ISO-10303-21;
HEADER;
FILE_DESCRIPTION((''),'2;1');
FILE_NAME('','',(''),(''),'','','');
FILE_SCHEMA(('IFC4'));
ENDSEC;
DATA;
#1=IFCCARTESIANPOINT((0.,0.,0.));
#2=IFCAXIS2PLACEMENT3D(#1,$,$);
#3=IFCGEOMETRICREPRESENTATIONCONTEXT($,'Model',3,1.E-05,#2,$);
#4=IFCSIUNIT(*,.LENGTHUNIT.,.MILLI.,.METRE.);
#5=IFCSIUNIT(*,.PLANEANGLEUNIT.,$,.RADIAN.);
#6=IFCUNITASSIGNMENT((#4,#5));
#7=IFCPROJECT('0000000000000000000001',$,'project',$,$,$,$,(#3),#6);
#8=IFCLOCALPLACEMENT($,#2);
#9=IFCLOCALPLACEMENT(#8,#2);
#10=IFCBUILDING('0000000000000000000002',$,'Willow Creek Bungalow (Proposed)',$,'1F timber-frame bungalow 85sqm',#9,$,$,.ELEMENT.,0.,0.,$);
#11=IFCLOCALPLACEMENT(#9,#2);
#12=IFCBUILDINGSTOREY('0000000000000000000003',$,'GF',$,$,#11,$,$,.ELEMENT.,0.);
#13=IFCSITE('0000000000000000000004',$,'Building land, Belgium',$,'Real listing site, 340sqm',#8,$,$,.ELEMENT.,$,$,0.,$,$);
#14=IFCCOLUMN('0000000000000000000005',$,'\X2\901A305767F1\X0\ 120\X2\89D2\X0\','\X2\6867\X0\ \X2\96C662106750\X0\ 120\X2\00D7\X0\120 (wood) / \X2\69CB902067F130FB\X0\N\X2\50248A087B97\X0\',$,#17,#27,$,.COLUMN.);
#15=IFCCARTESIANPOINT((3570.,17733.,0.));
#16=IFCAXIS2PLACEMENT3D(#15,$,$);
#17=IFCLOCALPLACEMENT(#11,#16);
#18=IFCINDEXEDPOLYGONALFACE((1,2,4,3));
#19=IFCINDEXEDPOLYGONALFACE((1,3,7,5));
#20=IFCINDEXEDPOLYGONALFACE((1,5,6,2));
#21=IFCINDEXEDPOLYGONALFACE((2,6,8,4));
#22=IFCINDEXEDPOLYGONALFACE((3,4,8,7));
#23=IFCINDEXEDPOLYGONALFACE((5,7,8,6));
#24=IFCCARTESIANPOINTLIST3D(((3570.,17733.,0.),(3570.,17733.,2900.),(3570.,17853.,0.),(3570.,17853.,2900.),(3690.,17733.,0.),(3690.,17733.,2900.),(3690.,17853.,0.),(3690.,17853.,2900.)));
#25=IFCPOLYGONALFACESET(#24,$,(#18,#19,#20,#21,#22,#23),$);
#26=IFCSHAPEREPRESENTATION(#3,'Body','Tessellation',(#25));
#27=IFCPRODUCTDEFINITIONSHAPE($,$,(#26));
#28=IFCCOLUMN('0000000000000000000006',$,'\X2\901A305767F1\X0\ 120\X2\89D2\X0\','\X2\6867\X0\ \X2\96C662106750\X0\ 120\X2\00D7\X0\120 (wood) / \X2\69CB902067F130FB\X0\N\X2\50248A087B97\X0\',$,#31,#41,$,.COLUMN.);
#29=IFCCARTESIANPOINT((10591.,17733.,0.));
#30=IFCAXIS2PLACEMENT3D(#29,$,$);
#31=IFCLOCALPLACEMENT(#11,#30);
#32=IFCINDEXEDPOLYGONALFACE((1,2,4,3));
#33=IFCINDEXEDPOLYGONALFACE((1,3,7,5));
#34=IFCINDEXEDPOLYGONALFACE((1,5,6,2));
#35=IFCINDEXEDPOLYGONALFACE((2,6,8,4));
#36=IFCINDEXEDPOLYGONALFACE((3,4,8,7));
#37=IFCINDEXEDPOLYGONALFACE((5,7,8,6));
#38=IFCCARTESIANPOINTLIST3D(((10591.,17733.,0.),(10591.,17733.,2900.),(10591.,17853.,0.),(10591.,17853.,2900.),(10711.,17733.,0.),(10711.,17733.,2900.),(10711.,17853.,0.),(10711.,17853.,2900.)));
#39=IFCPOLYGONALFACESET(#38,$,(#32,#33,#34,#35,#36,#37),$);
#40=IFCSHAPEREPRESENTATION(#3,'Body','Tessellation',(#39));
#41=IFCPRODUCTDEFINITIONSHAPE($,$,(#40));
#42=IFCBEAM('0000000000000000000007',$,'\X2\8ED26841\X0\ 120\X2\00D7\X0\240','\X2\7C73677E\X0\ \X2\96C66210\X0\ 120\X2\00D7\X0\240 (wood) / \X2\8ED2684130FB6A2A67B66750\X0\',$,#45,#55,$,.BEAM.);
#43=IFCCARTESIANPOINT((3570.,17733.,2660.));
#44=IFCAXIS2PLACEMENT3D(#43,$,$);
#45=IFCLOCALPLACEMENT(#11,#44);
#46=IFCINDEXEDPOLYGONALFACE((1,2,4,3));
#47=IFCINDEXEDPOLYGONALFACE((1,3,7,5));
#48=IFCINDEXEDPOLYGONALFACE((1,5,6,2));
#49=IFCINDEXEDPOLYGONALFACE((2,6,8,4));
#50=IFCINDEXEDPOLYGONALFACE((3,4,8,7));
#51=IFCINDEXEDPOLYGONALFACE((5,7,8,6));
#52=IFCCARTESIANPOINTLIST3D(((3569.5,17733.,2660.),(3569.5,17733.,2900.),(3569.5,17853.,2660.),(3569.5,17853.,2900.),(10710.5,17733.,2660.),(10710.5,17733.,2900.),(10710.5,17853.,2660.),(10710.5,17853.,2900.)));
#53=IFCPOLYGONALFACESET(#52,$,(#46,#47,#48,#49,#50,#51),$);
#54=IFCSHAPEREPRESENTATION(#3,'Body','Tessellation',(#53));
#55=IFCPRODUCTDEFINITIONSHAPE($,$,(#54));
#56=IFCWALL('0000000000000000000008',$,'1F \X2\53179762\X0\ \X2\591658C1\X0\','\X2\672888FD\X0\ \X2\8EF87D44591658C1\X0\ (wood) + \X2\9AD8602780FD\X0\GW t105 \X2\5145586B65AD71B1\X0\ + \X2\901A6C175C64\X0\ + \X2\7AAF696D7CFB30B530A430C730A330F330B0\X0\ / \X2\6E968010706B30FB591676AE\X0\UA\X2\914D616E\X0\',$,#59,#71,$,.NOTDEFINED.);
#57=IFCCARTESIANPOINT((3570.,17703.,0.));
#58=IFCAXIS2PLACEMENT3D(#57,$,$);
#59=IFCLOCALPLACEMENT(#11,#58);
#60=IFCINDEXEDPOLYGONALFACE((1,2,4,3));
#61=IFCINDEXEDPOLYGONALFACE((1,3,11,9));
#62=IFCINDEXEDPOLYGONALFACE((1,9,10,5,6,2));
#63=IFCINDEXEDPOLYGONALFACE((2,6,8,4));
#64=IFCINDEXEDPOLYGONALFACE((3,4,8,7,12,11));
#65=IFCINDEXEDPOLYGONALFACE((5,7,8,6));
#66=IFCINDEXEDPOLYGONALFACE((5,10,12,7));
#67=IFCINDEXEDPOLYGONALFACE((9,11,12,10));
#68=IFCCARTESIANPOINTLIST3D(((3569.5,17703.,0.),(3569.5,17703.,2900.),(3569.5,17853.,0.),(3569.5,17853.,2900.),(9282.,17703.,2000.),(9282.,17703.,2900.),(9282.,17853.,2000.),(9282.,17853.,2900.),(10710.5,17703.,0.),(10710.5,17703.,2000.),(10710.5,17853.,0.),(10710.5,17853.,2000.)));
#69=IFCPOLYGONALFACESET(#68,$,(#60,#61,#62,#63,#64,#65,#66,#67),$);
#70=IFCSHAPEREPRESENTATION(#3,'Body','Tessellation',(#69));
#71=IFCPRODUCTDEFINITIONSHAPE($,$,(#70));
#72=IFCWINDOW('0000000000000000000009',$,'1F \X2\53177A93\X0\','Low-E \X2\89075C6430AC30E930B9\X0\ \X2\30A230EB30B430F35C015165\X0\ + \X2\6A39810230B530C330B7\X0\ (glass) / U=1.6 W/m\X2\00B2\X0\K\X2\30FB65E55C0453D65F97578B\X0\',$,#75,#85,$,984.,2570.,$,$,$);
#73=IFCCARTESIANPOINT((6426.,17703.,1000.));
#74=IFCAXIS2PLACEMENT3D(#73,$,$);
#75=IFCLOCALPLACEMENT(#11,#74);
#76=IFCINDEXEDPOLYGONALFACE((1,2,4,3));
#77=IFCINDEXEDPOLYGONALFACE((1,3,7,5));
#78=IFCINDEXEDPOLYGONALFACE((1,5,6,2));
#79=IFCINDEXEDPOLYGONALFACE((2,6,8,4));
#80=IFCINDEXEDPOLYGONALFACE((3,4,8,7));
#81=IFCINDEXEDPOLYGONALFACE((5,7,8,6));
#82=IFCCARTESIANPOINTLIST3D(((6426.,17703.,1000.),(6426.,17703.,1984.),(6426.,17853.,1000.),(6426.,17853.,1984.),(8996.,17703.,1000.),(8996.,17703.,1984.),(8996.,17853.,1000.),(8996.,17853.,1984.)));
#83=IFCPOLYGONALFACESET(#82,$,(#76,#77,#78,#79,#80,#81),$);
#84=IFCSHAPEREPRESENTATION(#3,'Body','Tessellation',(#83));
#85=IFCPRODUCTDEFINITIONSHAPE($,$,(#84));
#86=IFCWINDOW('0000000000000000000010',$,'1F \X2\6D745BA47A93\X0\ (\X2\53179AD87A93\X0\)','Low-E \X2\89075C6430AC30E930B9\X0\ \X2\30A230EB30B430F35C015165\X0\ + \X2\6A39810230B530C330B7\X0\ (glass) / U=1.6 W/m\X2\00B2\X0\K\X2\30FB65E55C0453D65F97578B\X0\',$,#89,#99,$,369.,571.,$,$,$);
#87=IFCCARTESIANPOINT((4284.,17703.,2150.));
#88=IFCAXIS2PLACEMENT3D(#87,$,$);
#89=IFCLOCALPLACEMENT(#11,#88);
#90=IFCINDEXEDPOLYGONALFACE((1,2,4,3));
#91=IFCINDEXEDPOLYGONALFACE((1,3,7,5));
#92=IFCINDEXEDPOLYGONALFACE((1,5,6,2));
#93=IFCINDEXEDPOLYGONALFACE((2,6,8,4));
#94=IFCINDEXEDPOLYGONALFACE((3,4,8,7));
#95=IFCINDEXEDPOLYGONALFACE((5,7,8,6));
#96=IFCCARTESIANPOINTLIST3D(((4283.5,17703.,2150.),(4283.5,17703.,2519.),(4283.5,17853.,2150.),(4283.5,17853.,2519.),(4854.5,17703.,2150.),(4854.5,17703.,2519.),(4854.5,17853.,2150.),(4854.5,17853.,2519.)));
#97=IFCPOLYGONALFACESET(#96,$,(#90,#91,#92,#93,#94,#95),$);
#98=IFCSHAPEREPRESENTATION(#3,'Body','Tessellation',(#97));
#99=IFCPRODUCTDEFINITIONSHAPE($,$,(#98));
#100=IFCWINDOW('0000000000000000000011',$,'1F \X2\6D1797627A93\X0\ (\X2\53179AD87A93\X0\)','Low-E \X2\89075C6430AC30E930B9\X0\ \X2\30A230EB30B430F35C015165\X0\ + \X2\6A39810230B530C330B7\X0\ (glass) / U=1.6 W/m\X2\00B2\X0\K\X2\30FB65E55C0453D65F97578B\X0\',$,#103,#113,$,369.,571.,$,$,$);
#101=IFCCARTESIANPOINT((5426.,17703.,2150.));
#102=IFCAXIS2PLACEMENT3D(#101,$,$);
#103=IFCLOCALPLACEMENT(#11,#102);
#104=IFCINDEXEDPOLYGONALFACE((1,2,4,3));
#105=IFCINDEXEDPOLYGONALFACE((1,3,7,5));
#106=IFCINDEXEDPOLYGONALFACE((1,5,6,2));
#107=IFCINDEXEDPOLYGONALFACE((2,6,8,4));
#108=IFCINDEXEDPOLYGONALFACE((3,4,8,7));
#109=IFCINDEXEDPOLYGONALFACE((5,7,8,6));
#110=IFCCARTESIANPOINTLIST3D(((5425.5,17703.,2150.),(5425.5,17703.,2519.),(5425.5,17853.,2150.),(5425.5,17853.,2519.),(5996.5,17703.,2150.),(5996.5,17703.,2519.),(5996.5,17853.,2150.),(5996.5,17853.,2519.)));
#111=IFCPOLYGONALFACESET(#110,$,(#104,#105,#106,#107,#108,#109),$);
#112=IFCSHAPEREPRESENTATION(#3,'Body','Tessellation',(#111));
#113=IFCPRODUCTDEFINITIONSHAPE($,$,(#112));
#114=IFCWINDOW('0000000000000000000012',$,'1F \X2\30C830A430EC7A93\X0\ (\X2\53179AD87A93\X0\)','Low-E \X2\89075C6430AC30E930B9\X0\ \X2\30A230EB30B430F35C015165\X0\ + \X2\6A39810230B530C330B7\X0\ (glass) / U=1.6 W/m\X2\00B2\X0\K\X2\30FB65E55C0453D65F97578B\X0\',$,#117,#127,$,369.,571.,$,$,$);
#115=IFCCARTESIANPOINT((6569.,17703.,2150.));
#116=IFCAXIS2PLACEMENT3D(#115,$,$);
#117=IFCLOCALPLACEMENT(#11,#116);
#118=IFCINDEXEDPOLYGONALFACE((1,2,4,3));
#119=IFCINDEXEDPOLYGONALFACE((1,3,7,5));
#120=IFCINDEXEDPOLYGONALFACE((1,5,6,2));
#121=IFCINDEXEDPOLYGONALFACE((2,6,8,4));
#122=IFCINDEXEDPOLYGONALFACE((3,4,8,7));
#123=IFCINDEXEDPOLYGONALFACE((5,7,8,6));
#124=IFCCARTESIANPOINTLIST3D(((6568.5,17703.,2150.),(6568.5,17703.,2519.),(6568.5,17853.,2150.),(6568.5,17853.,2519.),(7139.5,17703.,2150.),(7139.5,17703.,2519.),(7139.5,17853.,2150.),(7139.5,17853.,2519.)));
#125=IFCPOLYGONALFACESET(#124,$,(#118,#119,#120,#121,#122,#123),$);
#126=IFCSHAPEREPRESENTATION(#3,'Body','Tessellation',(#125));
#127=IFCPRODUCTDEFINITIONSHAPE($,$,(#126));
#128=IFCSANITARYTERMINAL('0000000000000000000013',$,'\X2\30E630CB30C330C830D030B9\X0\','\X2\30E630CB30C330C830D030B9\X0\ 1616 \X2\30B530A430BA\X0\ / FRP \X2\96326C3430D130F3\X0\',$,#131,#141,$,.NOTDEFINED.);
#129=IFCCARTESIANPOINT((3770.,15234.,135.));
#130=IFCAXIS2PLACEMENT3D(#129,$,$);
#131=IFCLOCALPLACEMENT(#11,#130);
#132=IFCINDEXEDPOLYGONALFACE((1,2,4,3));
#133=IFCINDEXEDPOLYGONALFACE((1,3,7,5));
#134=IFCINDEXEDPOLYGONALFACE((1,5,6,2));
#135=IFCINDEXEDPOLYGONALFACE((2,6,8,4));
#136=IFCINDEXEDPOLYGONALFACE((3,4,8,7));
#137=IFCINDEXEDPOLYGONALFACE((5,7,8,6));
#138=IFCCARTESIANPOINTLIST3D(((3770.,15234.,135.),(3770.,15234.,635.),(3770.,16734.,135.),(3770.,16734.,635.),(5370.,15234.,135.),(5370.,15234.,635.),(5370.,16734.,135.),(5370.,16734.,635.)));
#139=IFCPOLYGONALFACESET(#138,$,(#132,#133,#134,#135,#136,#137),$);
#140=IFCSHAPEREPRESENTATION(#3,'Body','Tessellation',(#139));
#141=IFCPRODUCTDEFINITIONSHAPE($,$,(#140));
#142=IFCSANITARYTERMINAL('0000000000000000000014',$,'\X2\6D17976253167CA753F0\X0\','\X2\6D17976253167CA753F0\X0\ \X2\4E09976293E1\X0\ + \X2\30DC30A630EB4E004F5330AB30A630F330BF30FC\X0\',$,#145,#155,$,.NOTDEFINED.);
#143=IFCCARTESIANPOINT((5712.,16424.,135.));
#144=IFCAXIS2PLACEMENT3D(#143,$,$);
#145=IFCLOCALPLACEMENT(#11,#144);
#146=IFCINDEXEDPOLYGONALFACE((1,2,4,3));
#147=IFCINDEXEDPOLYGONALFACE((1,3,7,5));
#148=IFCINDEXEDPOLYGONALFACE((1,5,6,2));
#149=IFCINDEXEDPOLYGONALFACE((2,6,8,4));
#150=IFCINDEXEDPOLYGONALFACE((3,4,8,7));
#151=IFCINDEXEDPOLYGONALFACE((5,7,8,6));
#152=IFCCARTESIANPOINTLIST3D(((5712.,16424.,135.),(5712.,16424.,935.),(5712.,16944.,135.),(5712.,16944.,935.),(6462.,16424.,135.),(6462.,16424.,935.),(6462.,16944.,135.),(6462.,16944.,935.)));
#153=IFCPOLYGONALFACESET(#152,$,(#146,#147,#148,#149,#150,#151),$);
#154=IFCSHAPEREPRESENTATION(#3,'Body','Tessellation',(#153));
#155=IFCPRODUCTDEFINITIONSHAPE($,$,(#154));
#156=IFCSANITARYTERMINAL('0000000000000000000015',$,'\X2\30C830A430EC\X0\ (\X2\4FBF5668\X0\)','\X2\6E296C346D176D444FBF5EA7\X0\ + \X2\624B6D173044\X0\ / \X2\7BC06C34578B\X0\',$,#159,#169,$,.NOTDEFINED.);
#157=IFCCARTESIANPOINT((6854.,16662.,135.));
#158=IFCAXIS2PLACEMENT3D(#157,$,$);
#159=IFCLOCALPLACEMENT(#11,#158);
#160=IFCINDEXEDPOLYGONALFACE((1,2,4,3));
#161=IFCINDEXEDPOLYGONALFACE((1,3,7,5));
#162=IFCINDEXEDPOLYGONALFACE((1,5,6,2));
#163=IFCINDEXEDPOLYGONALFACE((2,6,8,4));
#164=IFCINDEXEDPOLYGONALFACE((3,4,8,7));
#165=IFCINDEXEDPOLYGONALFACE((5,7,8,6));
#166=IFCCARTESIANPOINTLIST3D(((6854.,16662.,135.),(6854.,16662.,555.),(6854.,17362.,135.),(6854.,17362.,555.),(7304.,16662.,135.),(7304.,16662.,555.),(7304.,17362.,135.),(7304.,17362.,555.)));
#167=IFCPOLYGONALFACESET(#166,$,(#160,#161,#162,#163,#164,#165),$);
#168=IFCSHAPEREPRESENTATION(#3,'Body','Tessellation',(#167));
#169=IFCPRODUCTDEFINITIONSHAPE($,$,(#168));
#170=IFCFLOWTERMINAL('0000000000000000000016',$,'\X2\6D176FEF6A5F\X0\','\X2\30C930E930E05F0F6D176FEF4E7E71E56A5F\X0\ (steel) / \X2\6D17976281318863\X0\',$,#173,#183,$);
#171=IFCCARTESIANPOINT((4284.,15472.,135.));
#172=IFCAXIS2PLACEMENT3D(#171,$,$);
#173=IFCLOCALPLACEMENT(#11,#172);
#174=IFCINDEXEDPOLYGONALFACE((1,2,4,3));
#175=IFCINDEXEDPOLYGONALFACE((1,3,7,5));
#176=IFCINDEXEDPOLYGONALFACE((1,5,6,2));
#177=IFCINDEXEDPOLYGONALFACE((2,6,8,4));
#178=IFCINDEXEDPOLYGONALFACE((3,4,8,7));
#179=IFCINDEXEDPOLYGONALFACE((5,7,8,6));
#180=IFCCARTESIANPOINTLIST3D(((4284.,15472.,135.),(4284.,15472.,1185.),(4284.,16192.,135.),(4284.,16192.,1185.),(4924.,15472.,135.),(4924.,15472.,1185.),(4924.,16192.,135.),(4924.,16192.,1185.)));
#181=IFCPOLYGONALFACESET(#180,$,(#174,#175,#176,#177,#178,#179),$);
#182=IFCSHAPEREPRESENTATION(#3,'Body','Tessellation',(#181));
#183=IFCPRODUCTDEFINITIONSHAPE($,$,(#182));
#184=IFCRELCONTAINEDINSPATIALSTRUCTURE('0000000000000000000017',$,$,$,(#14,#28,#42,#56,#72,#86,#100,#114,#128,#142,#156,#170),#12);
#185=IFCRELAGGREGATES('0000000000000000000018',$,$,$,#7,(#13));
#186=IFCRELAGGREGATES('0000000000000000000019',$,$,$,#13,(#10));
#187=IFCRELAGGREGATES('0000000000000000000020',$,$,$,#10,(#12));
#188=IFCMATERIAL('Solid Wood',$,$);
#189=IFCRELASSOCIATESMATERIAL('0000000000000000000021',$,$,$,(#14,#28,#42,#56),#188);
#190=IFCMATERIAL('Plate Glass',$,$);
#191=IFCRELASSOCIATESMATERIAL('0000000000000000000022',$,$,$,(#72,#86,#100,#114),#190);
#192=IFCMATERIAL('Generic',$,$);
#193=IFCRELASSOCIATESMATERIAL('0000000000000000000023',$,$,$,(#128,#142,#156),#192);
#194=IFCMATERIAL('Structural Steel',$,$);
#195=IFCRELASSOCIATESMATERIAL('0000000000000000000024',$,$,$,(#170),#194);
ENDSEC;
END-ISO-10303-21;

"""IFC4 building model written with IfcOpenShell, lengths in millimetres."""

from ifc_helpers import new_model, si_unit, frame, frame_2d, origin, place, context, project, spatial, rectangle, extrude, material, element, fill, save


model = new_model("IFC4")

# Units and contexts
model_context = context("Model", 3, precision=1e-05, world=origin())
ifc_project = project(units=[si_unit("LENGTHUNIT", "METRE", prefix="MILLI"), si_unit("PLANEANGLEUNIT", "RADIAN")], contexts=[model_context])

# Site, building, storey
site_placement = place(None, origin())
site = spatial("IfcSite", under=ifc_project, at=site_placement, Name="Building land, Belgium", ObjectType="Real listing site, 340sqm", CompositionType="ELEMENT", RefElevation=0.0)
building_placement = place(site_placement, origin())
building = spatial("IfcBuilding", under=site, at=building_placement, Name="Willow Creek Bungalow (Proposed)", ObjectType="1F timber-frame bungalow 85sqm", CompositionType="ELEMENT", ElevationOfRefHeight=0.0, ElevationOfTerrain=0.0)
storey_placement = place(building_placement, origin())
storey = spatial("IfcBuildingStorey", under=building, at=storey_placement, Name="GF", CompositionType="ELEMENT", Elevation=0.0)

# Columns
ifc_material_1 = material(Name="Solid Wood")
column_1_placement = place(storey_placement, frame((3570.0, 17733.0, 0.0)))
element("IfcColumn", 1, at=column_1_placement, inside=storey, material=ifc_material_1, Name="通し柱 120角", Description="桧 集成材 120×120 (wood) / 構造柱・N値計算", PredefinedType="COLUMN", context=model_context, shape_type="SweptSolid", body=[
    extrude(rectangle(XDim=120.0, YDim=120.0, at=frame_2d((60.0, 60.0))), frame((3570.0, 17733.0, 0.0)), (0.0, 0.0, 1.0), 2900.0),
])
column_2_placement = place(storey_placement, frame((10591.0, 17733.0, 0.0)))
element("IfcColumn", 2, at=column_2_placement, inside=storey, material=ifc_material_1, Name="通し柱 120角", Description="桧 集成材 120×120 (wood) / 構造柱・N値計算", PredefinedType="COLUMN", context=model_context, shape_type="SweptSolid", body=[
    extrude(rectangle(XDim=120.0, YDim=120.0, at=frame_2d((60.0, 60.0))), frame((10591.0, 17733.0, 0.0)), (0.0, 0.0, 1.0), 2900.0),
])

# Beam
beam_1_placement = place(storey_placement, frame((3570.0, 17733.0, 2660.0)))
element("IfcBeam", 3, at=beam_1_placement, inside=storey, material=ifc_material_1, Name="軒桁 120×240", Description="米松 集成 120×240 (wood) / 軒桁・横架材", PredefinedType="BEAM", context=model_context, shape_type="SweptSolid", body=[
    extrude(rectangle(XDim=7141.0, YDim=120.0, at=frame_2d((3570.0, 60.0))), frame((3570.0, 17733.0, 2660.0)), (0.0, 0.0, 1.0), 240.0),
])

# Wall, openings, windows
wall_placement = place(storey_placement, frame((3570.0, 17703.0, 0.0)))
wall = element("IfcWall", 4, at=wall_placement, inside=storey, material=ifc_material_1, Name="1F 北面 外壁", Description="木製 軸組外壁 (wood) + 高性能GW t105 充填断熱 + 通気層 + 窯業系サイディング / 準耐火・外皮UA配慮", PredefinedType="NOTDEFINED", context=model_context, shape_type="SweptSolid", body=[
    extrude(rectangle(XDim=7141.0, YDim=150.0, at=frame_2d((3570.0, 75.0))), frame((3570.0, 17703.0, 0.0)), (0.0, 0.0, 1.0), 2900.0),
])
opening_1_placement = place(storey_placement, frame((6426.0, 17703.0, 1000.0)))
opening_1 = element("IfcOpeningElement", 5, at=opening_1_placement, cuts=wall, PredefinedType="NOTDEFINED", context=model_context, shape_type="SweptSolid", body=[
    extrude(rectangle(XDim=2570.0, YDim=150.0, at=frame_2d((1285.0, 75.0))), frame((6426.0, 17703.0, 1000.0)), (0.0, 0.0, 1.0), 984.0),
])
opening_2_placement = place(storey_placement, frame((4284.0, 17703.0, 2150.0)))
opening_2 = element("IfcOpeningElement", 6, at=opening_2_placement, cuts=wall, PredefinedType="NOTDEFINED", context=model_context, shape_type="SweptSolid", body=[
    extrude(rectangle(XDim=571.0, YDim=150.0, at=frame_2d((285.0, 75.0))), frame((4284.0, 17703.0, 2150.0)), (0.0, 0.0, 1.0), 369.0),
])
opening_3_placement = place(storey_placement, frame((5426.0, 17703.0, 2150.0)))
opening_3 = element("IfcOpeningElement", 7, at=opening_3_placement, cuts=wall, PredefinedType="NOTDEFINED", context=model_context, shape_type="SweptSolid", body=[
    extrude(rectangle(XDim=571.0, YDim=150.0, at=frame_2d((285.0, 75.0))), frame((5426.0, 17703.0, 2150.0)), (0.0, 0.0, 1.0), 369.0),
])
opening_4_placement = place(storey_placement, frame((6569.0, 17703.0, 2150.0)))
opening_4 = element("IfcOpeningElement", 8, at=opening_4_placement, cuts=wall, PredefinedType="NOTDEFINED", context=model_context, shape_type="SweptSolid", body=[
    extrude(rectangle(XDim=571.0, YDim=150.0, at=frame_2d((285.0, 75.0))), frame((6569.0, 17703.0, 2150.0)), (0.0, 0.0, 1.0), 369.0),
])
ifc_material_2 = material(Name="Plate Glass")
window_1_placement = place(storey_placement, frame((6426.0, 17703.0, 1000.0)))
window_1 = element("IfcWindow", 9, at=window_1_placement, inside=storey, material=ifc_material_2, Name="1F 北窓", Description="Low-E 複層ガラス アルゴン封入 + 樹脂サッシ (glass) / U=1.6 W/m²K・日射取得型", OverallHeight=984.0, OverallWidth=2570.0, context=model_context, shape_type="SweptSolid", body=[
    extrude(rectangle(XDim=2570.0, YDim=150.0, at=frame_2d((1285.0, 75.0))), frame((6426.0, 17703.0, 1000.0)), (0.0, 0.0, 1.0), 984.0),
])
fill(opening_1, window_1)
window_2_placement = place(storey_placement, frame((4284.0, 17703.0, 2150.0)))
window_2 = element("IfcWindow", 10, at=window_2_placement, inside=storey, material=ifc_material_2, Name="1F 浴室窓 (北高窓)", Description="Low-E 複層ガラス アルゴン封入 + 樹脂サッシ (glass) / U=1.6 W/m²K・日射取得型", OverallHeight=369.0, OverallWidth=571.0, context=model_context, shape_type="SweptSolid", body=[
    extrude(rectangle(XDim=571.0, YDim=150.0, at=frame_2d((285.0, 75.0))), frame((4284.0, 17703.0, 2150.0)), (0.0, 0.0, 1.0), 369.0),
])
fill(opening_2, window_2)
window_3_placement = place(storey_placement, frame((5426.0, 17703.0, 2150.0)))
window_3 = element("IfcWindow", 11, at=window_3_placement, inside=storey, material=ifc_material_2, Name="1F 洗面窓 (北高窓)", Description="Low-E 複層ガラス アルゴン封入 + 樹脂サッシ (glass) / U=1.6 W/m²K・日射取得型", OverallHeight=369.0, OverallWidth=571.0, context=model_context, shape_type="SweptSolid", body=[
    extrude(rectangle(XDim=571.0, YDim=150.0, at=frame_2d((285.0, 75.0))), frame((5426.0, 17703.0, 2150.0)), (0.0, 0.0, 1.0), 369.0),
])
fill(opening_3, window_3)
window_4_placement = place(storey_placement, frame((6569.0, 17703.0, 2150.0)))
window_4 = element("IfcWindow", 12, at=window_4_placement, inside=storey, material=ifc_material_2, Name="1F トイレ窓 (北高窓)", Description="Low-E 複層ガラス アルゴン封入 + 樹脂サッシ (glass) / U=1.6 W/m²K・日射取得型", OverallHeight=369.0, OverallWidth=571.0, context=model_context, shape_type="SweptSolid", body=[
    extrude(rectangle(XDim=571.0, YDim=150.0, at=frame_2d((285.0, 75.0))), frame((6569.0, 17703.0, 2150.0)), (0.0, 0.0, 1.0), 369.0),
])
fill(opening_4, window_4)

# Sanitary terminals
ifc_material_3 = material(Name="Generic")
sanitary_terminal_1_placement = place(storey_placement, frame((3770.0, 15234.0, 135.0)))
element("IfcSanitaryTerminal", 13, at=sanitary_terminal_1_placement, inside=storey, material=ifc_material_3, Name="ユニットバス", Description="ユニットバス 1616 サイズ / FRP 防水パン", PredefinedType="NOTDEFINED", context=model_context, shape_type="SweptSolid", body=[
    extrude(rectangle(XDim=1600.0, YDim=1500.0, at=frame_2d((800.0, 750.0))), frame((3770.0, 15234.0, 135.0)), (0.0, 0.0, 1.0), 500.0),
])
sanitary_terminal_2_placement = place(storey_placement, frame((5712.0, 16424.0, 135.0)))
element("IfcSanitaryTerminal", 14, at=sanitary_terminal_2_placement, inside=storey, material=ifc_material_3, Name="洗面化粧台", Description="洗面化粧台 三面鏡 + ボウル一体カウンター", PredefinedType="NOTDEFINED", context=model_context, shape_type="SweptSolid", body=[
    extrude(rectangle(XDim=750.0, YDim=520.0, at=frame_2d((375.0, 260.0))), frame((5712.0, 16424.0, 135.0)), (0.0, 0.0, 1.0), 800.0),
])
sanitary_terminal_3_placement = place(storey_placement, frame((6854.0, 16662.0, 135.0)))
element("IfcSanitaryTerminal", 15, at=sanitary_terminal_3_placement, inside=storey, material=ifc_material_3, Name="トイレ (便器)", Description="温水洗浄便座 + 手洗い / 節水型", PredefinedType="NOTDEFINED", context=model_context, shape_type="SweptSolid", body=[
    extrude(rectangle(XDim=450.0, YDim=700.0, at=frame_2d((225.0, 350.0))), frame((6854.0, 16662.0, 135.0)), (0.0, 0.0, 1.0), 420.0),
])

# Flow terminal
ifc_material_4 = material(Name="Structural Steel")
flow_terminal_placement = place(storey_placement, frame((4284.0, 15472.0, 135.0)))
element("IfcFlowTerminal", 16, at=flow_terminal_placement, inside=storey, material=ifc_material_4, Name="洗濯機", Description="ドラム式洗濯乾燥機 (steel) / 洗面脱衣", context=model_context, shape_type="SweptSolid", body=[
    extrude(rectangle(XDim=640.0, YDim=720.0, at=frame_2d((320.0, 360.0))), frame((4284.0, 15472.0, 135.0)), (0.0, 0.0, 1.0), 1050.0),
])

save(model, "model.ifc")
